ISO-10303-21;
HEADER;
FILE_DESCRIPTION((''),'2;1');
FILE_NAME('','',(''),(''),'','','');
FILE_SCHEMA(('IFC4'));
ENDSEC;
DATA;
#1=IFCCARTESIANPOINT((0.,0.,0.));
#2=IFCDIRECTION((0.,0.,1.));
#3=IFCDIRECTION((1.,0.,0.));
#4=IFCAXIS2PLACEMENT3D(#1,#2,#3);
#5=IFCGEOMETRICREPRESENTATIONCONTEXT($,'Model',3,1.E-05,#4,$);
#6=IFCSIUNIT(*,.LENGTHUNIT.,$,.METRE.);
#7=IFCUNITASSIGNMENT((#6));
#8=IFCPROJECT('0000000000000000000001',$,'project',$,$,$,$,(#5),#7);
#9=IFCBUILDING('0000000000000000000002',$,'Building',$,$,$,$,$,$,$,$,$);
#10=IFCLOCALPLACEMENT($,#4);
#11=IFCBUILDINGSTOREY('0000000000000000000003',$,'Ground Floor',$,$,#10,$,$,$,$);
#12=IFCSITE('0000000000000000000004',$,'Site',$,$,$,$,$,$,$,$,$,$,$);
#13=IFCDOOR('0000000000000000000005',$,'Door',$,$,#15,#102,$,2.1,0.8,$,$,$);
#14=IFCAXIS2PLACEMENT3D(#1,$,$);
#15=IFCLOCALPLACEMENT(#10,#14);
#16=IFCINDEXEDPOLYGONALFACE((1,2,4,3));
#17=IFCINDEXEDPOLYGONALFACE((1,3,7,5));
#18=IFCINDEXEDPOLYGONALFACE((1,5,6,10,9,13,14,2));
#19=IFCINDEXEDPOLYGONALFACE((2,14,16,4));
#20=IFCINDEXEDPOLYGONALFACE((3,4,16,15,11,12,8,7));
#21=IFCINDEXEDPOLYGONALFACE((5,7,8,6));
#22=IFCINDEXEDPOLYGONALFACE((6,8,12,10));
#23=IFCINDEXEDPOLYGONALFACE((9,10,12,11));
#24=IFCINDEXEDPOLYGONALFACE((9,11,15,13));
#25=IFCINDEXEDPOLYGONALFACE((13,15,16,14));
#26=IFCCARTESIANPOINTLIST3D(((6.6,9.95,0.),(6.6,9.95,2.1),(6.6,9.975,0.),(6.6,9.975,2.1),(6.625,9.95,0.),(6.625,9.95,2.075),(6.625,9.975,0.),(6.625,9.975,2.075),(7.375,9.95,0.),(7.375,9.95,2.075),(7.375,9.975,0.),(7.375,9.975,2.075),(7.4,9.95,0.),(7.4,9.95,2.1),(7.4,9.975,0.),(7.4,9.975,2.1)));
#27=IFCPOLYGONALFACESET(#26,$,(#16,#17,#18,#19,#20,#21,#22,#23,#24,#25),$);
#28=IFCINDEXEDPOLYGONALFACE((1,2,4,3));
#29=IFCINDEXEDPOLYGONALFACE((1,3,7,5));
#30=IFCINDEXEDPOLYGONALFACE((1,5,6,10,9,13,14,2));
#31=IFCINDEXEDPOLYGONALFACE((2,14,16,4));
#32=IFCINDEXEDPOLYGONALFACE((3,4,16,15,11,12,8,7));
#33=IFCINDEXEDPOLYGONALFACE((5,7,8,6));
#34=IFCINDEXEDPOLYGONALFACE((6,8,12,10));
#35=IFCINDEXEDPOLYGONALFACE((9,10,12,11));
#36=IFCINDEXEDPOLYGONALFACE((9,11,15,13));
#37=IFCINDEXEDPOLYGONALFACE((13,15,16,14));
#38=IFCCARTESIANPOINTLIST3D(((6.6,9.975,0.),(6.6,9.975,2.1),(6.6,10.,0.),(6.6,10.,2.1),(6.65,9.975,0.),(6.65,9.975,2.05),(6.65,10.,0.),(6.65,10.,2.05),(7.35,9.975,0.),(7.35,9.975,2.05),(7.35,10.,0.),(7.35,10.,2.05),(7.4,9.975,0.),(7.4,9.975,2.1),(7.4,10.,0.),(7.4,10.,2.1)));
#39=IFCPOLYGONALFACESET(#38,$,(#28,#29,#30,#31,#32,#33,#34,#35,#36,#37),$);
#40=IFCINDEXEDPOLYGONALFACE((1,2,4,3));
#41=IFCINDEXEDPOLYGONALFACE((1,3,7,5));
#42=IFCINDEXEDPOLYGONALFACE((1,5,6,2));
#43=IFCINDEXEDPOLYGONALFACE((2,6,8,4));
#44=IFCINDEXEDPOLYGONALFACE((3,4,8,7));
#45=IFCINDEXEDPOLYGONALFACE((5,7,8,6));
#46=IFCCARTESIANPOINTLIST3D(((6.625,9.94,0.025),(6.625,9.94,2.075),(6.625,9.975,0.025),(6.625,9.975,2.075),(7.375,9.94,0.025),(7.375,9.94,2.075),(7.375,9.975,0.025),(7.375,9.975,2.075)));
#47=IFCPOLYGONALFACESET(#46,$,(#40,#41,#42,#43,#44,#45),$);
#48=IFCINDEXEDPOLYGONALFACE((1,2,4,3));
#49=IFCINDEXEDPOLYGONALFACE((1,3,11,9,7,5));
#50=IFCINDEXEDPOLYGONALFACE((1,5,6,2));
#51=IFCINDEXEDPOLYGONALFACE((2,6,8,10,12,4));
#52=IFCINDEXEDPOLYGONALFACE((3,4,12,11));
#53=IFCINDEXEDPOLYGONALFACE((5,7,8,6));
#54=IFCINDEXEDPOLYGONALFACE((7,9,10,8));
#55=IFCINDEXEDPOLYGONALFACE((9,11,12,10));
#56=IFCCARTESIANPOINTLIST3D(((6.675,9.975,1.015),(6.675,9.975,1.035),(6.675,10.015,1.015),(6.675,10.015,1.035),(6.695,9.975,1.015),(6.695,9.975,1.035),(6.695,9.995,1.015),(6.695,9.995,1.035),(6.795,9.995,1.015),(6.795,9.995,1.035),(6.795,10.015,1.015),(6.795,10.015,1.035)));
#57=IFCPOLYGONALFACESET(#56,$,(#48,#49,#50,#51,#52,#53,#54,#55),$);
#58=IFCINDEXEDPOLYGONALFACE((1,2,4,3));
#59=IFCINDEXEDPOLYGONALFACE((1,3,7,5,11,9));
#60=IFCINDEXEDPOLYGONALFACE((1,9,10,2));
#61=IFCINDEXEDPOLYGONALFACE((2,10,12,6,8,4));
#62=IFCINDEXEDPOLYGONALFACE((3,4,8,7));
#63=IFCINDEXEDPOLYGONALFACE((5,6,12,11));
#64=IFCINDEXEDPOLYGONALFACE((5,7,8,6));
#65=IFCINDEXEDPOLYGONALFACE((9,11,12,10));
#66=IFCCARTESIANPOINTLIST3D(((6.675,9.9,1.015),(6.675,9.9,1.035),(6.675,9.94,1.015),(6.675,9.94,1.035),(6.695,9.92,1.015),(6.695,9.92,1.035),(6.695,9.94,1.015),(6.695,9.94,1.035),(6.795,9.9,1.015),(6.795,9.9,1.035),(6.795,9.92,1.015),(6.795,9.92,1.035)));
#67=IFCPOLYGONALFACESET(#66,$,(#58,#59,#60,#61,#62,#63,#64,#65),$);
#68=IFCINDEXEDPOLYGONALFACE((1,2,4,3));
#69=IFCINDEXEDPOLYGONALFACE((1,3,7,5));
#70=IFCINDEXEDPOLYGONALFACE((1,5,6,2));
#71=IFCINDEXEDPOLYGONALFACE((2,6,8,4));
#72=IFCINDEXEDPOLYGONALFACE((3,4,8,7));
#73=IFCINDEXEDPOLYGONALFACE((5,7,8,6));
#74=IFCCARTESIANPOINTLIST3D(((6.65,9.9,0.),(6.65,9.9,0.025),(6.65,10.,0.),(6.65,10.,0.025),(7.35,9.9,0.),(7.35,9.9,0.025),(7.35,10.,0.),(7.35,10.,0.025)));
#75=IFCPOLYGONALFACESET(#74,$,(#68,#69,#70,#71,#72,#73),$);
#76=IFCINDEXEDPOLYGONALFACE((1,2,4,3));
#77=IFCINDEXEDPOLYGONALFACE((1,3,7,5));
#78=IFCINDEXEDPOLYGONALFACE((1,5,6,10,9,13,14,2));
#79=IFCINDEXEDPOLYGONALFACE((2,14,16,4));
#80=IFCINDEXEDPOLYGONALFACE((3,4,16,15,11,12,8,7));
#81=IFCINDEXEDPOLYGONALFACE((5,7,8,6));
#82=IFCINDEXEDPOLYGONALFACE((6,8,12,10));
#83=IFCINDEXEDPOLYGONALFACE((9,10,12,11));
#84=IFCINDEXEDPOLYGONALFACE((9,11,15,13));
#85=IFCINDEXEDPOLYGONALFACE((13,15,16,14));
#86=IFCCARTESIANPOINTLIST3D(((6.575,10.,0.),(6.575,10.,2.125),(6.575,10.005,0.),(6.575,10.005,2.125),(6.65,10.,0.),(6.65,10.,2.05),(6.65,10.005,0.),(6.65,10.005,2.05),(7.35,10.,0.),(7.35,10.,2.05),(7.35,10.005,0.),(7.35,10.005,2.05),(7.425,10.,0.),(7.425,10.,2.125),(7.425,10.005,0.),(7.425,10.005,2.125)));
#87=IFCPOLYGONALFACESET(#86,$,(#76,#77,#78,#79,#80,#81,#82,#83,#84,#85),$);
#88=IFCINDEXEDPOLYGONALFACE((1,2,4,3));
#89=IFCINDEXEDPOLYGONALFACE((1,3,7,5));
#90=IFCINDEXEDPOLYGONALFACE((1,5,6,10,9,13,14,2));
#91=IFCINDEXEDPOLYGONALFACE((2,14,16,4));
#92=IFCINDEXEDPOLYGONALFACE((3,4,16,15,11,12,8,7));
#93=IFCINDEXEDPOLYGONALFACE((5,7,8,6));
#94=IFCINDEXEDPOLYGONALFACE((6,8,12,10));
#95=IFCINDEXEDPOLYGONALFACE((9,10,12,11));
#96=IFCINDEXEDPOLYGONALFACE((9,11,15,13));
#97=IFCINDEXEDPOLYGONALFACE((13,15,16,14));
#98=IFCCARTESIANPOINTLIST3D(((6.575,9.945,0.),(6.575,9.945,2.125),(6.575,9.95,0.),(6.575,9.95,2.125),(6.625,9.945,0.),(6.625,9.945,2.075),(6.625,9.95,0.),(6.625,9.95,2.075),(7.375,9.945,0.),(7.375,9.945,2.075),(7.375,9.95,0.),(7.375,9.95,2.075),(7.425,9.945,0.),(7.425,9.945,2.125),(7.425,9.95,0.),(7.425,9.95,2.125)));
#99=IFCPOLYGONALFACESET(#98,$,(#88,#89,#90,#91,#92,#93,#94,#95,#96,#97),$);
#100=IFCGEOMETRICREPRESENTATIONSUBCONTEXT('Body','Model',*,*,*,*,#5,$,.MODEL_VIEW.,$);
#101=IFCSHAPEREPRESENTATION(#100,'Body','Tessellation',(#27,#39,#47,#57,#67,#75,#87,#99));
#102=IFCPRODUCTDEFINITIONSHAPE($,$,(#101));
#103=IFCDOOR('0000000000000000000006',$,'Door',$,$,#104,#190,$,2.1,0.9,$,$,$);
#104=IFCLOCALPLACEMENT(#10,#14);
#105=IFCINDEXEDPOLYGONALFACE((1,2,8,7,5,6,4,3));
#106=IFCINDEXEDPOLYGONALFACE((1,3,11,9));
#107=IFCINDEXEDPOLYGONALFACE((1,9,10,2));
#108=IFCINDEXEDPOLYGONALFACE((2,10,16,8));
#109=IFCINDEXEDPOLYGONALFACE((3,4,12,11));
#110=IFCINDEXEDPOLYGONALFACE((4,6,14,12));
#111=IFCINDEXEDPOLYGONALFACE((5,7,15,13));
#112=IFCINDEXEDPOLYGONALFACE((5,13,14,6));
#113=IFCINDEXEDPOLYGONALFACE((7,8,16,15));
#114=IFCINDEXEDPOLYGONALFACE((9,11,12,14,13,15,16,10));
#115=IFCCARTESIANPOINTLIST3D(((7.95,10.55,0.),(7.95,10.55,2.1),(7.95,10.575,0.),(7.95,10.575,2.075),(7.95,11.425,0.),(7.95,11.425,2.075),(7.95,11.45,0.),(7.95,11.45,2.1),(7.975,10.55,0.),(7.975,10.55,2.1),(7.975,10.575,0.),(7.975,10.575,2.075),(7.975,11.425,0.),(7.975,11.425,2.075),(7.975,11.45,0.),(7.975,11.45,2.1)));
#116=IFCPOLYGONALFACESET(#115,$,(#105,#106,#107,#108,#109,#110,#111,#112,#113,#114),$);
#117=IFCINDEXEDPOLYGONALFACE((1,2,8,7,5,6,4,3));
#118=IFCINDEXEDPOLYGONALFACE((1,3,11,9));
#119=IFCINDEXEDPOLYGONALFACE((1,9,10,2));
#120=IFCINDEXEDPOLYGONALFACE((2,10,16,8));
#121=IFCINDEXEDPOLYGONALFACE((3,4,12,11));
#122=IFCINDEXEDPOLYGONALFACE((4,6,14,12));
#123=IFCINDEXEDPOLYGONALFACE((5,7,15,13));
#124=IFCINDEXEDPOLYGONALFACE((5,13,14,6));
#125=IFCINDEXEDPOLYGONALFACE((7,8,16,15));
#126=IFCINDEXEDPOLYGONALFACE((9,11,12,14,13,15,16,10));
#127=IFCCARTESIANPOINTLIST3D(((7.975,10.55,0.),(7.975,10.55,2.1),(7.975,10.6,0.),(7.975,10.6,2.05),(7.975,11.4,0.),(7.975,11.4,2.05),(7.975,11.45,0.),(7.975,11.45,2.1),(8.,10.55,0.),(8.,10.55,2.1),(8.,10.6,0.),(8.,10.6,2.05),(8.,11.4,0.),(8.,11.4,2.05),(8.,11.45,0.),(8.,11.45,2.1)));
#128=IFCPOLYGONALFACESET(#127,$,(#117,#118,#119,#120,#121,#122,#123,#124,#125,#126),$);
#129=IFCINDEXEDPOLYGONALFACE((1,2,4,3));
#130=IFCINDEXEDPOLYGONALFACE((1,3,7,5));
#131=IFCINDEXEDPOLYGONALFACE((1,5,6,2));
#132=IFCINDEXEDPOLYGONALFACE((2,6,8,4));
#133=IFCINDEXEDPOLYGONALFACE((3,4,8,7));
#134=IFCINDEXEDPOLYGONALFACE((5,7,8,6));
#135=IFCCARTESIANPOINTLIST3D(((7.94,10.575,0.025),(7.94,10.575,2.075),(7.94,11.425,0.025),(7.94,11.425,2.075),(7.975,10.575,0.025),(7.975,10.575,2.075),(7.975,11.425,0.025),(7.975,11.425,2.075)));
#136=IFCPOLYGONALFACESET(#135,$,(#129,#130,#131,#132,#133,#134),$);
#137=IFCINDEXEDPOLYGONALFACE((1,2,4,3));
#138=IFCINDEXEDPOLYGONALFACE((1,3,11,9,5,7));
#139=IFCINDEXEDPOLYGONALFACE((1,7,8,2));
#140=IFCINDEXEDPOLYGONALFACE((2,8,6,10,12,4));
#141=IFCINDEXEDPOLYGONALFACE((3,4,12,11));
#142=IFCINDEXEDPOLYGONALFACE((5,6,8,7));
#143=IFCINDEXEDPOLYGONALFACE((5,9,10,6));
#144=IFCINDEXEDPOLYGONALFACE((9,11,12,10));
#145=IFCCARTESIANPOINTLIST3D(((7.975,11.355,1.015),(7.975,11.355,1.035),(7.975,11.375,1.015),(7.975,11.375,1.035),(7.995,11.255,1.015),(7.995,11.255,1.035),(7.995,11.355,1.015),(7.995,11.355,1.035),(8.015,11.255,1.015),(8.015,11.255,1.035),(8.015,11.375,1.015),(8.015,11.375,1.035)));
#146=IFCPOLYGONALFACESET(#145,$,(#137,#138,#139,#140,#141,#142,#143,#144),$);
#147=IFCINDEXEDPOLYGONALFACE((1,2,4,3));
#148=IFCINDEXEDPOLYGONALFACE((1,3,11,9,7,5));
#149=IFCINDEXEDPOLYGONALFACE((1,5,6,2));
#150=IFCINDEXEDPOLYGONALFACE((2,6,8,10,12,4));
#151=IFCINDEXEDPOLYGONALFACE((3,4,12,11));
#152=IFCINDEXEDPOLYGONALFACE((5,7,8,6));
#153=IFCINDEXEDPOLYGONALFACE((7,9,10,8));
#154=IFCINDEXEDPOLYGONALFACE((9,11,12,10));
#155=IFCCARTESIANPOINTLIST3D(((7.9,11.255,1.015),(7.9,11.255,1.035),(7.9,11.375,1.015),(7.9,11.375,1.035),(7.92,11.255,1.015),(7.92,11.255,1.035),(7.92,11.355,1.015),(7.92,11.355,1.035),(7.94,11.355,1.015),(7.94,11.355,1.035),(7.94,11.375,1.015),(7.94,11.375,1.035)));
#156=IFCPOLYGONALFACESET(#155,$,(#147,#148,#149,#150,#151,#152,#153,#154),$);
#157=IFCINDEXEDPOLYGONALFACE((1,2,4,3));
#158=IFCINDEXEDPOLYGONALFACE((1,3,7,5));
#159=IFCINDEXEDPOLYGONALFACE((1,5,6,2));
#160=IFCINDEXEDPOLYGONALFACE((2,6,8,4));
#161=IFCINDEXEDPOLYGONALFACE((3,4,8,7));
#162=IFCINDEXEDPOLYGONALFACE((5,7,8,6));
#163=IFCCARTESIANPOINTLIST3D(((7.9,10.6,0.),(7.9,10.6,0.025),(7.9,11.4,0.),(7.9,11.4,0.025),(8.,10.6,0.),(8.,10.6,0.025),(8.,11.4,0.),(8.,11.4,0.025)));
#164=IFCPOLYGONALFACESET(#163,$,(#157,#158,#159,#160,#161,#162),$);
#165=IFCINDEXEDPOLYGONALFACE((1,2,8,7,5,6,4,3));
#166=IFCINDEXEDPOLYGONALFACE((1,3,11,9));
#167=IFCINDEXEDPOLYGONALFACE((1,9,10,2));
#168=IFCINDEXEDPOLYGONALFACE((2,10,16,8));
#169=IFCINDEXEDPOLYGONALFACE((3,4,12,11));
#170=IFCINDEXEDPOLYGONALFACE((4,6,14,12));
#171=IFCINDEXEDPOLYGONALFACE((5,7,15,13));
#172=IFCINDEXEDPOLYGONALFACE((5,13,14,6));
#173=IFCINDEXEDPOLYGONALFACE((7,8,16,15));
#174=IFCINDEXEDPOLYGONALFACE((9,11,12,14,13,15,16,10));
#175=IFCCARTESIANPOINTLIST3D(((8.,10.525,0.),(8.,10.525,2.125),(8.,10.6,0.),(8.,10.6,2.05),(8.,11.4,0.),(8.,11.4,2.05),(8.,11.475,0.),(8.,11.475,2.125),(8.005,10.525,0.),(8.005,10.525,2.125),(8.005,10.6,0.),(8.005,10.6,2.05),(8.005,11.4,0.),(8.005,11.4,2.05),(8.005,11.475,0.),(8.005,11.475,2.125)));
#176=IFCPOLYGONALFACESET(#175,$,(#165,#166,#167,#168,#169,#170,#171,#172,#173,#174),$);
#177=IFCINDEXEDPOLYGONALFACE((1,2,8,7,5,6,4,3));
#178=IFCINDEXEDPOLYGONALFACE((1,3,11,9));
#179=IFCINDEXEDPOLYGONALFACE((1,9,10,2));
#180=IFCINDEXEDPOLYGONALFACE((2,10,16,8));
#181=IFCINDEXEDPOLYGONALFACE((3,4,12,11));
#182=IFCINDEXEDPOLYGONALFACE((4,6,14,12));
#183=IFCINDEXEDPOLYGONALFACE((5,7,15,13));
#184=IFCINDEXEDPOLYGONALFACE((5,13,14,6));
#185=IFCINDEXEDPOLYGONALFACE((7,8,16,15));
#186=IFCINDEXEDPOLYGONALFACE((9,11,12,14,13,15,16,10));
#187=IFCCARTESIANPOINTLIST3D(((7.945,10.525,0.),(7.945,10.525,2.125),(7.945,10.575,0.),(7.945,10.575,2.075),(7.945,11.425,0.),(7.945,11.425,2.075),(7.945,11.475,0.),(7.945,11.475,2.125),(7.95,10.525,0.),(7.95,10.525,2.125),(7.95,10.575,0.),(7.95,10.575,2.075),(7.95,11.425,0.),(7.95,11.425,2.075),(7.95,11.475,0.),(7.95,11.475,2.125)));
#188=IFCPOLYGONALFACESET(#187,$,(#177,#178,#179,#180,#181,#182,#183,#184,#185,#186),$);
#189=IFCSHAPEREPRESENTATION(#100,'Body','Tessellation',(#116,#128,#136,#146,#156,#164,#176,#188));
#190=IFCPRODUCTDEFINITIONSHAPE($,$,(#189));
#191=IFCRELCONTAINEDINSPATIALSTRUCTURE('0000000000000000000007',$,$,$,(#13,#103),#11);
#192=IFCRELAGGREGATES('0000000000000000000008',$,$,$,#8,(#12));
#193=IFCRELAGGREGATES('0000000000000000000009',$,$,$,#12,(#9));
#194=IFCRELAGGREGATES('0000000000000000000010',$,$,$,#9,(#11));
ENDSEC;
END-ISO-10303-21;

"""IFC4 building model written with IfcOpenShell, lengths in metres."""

from ifc_helpers import new_model, si_unit, frame, origin_with_axes, place, context, subcontext, project, spatial, line, indexed_curve, outline, extrude, element, save


model = new_model("IFC4")

# Units and contexts
model_context = context("Model", 3, precision=1e-05, world=origin_with_axes())
body_context = subcontext(model_context, "Body", "Model", "MODEL_VIEW")
ifc_project = project(units=[si_unit("LENGTHUNIT", "METRE")], contexts=[model_context])

# Site, building, storey
site = spatial("IfcSite", under=ifc_project, Name="Site")
building = spatial("IfcBuilding", under=site, Name="Building")
storey_placement = place(None, origin_with_axes())
storey = spatial("IfcBuildingStorey", under=building, at=storey_placement, Name="Ground Floor")

# Doors
door_1_placement = place(storey_placement, frame((7.4, 10.0, 0.0), z_axis=(0.0, 0.0, 1.0), x_axis=(-1.0, 0.0, 0.0)))
element("IfcDoor", 1, at=door_1_placement, inside=storey, Name="Door", OverallHeight=2.1, OverallWidth=0.8, context=body_context, shape_type="SweptSolid", body=[
    extrude(outline(indexed_curve([(0.0, 0.0), (0.0, 2.1), (0.8, 2.1), (0.8, 0.0), (0.775, 0.0), (0.775, 2.075), (0.025, 2.075), (0.025, 0.0)], segments=[line(1, 2, 3, 4, 5, 6, 7, 8, 1)])), frame((0.0, 0.025, 0.0), z_axis=(0.0, -1.0, 0.0), x_axis=(1.0, 0.0, 0.0)), (0.0, 0.0, -1.0), 0.025),
    extrude(outline(indexed_curve([(0.0, 0.0), (0.0, 2.1), (0.8, 2.1), (0.8, 0.0), (0.75, 0.0), (0.75, 2.05), (0.05, 2.05), (0.05, 0.0)], segments=[line(1, 2, 3, 4, 5, 6, 7, 8, 1)])), frame((0.0, 0.0, 0.0), z_axis=(0.0, -1.0, 0.0), x_axis=(1.0, 0.0, 0.0)), (0.0, 0.0, -1.0), 0.025),
    extrude(outline(indexed_curve([(0.0, 0.0), (0.75, 0.0), (0.75, 0.035), (0.0, 0.035)], segments=[line(1, 2, 3, 4, 1)])), frame((0.025, 0.025, 0.025), z_axis=(0.0, 0.0, 1.0), x_axis=(1.0, 0.0, 0.0)), (0.0, 0.0, 1.0), 2.05),
    extrude(outline(indexed_curve([(0.0, 0.0), (0.0, -0.04), (-0.12, -0.04), (-0.12, -0.02), (-0.02, -0.02), (-0.02, 0.0)], segments=[line(1, 2, 3, 4, 5, 6, 1)])), frame((0.725, 0.025, 1.015), z_axis=(0.0, 0.0, 1.0), x_axis=(1.0, 0.0, 0.0)), (0.0, 0.0, 1.0), 0.02),
    extrude(outline(indexed_curve([(0.0, 0.0), (0.0, 0.04), (-0.12, 0.04), (-0.12, 0.02), (-0.02, 0.02), (-0.02, 0.0)], segments=[line(1, 2, 3, 4, 5, 6, 1)])), frame((0.725, 0.06, 1.015), z_axis=(0.0, 0.0, 1.0), x_axis=(1.0, 0.0, 0.0)), (0.0, 0.0, 1.0), 0.02),
    extrude(outline(indexed_curve([(0.0, 0.0), (0.7, 0.0), (0.7, 0.1), (0.0, 0.1)], segments=[line(1, 2, 3, 4, 1)])), frame((0.05, 0.0, 0.0), z_axis=(0.0, 0.0, 1.0), x_axis=(1.0, 0.0, 0.0)), (0.0, 0.0, 1.0), 0.025),
    extrude(outline(indexed_curve([(0.0, 0.0), (0.0, 2.125), (0.85, 2.125), (0.85, 0.0), (0.775, 0.0), (0.775, 2.05), (0.075, 2.05), (0.075, 0.0)], segments=[line(1, 2, 3, 4, 5, 6, 7, 8, 1)])), frame((-0.025, -0.005, 0.0), z_axis=(0.0, -1.0, 0.0), x_axis=(1.0, 0.0, 0.0)), (0.0, 0.0, -1.0), 0.005),
    extrude(outline(indexed_curve([(0.0, 0.0), (0.0, 2.125), (0.85, 2.125), (0.85, 0.0), (0.8, 0.0), (0.8, 2.075), (0.05, 2.075), (0.05, 0.0)], segments=[line(1, 2, 3, 4, 5, 6, 7, 8, 1)])), frame((-0.025, 0.05, 0.0), z_axis=(0.0, -1.0, 0.0), x_axis=(1.0, 0.0, 0.0)), (0.0, 0.0, -1.0), 0.005),
])
door_2_placement = place(storey_placement, frame((8.0, 10.55, 0.0), z_axis=(0.0, 0.0, 1.0), x_axis=(0.0, 1.0, 0.0)))
element("IfcDoor", 2, at=door_2_placement, inside=storey, Name="Door", OverallHeight=2.1, OverallWidth=0.9, context=body_context, shape_type="SweptSolid", body=[
    extrude(outline(indexed_curve([(0.0, 0.0), (0.0, 2.1), (0.9, 2.1), (0.9, 0.0), (0.875, 0.0), (0.875, 2.075), (0.025, 2.075), (0.025, 0.0)], segments=[line(1, 2, 3, 4, 5, 6, 7, 8, 1)])), frame((0.0, 0.025, 0.0), z_axis=(0.0, -1.0, 0.0), x_axis=(1.0, 0.0, 0.0)), (0.0, 0.0, -1.0), 0.025),
    extrude(outline(indexed_curve([(0.0, 0.0), (0.0, 2.1), (0.9, 2.1), (0.9, 0.0), (0.85, 0.0), (0.85, 2.05), (0.05, 2.05), (0.05, 0.0)], segments=[line(1, 2, 3, 4, 5, 6, 7, 8, 1)])), frame((0.0, 0.0, 0.0), z_axis=(0.0, -1.0, 0.0), x_axis=(1.0, 0.0, 0.0)), (0.0, 0.0, -1.0), 0.025),
    extrude(outline(indexed_curve([(0.0, 0.0), (0.85, 0.0), (0.85, 0.035), (0.0, 0.035)], segments=[line(1, 2, 3, 4, 1)])), frame((0.025, 0.025, 0.025), z_axis=(0.0, 0.0, 1.0), x_axis=(1.0, 0.0, 0.0)), (0.0, 0.0, 1.0), 2.05),
    extrude(outline(indexed_curve([(0.0, 0.0), (0.0, -0.04), (-0.12, -0.04), (-0.12, -0.02), (-0.02, -0.02), (-0.02, 0.0)], segments=[line(1, 2, 3, 4, 5, 6, 1)])), frame((0.825, 0.025, 1.015), z_axis=(0.0, 0.0, 1.0), x_axis=(1.0, 0.0, 0.0)), (0.0, 0.0, 1.0), 0.02),
    extrude(outline(indexed_curve([(0.0, 0.0), (0.0, 0.04), (-0.12, 0.04), (-0.12, 0.02), (-0.02, 0.02), (-0.02, 0.0)], segments=[line(1, 2, 3, 4, 5, 6, 1)])), frame((0.825, 0.06, 1.015), z_axis=(0.0, 0.0, 1.0), x_axis=(1.0, 0.0, 0.0)), (0.0, 0.0, 1.0), 0.02),
    extrude(outline(indexed_curve([(0.0, 0.0), (0.8, 0.0), (0.8, 0.1), (0.0, 0.1)], segments=[line(1, 2, 3, 4, 1)])), frame((0.05, 0.0, 0.0), z_axis=(0.0, 0.0, 1.0), x_axis=(1.0, 0.0, 0.0)), (0.0, 0.0, 1.0), 0.025),
    extrude(outline(indexed_curve([(0.0, 0.0), (0.0, 2.125), (0.95, 2.125), (0.95, 0.0), (0.875, 0.0), (0.875, 2.05), (0.075, 2.05), (0.075, 0.0)], segments=[line(1, 2, 3, 4, 5, 6, 7, 8, 1)])), frame((-0.025, -0.005, 0.0), z_axis=(0.0, -1.0, 0.0), x_axis=(1.0, 0.0, 0.0)), (0.0, 0.0, -1.0), 0.005),
    extrude(outline(indexed_curve([(0.0, 0.0), (0.0, 2.125), (0.95, 2.125), (0.95, 0.0), (0.9, 0.0), (0.9, 2.075), (0.05, 2.075), (0.05, 0.0)], segments=[line(1, 2, 3, 4, 5, 6, 7, 8, 1)])), frame((-0.025, 0.05, 0.0), z_axis=(0.0, -1.0, 0.0), x_axis=(1.0, 0.0, 0.0)), (0.0, 0.0, -1.0), 0.005),
])

save(model, "model.ifc")
